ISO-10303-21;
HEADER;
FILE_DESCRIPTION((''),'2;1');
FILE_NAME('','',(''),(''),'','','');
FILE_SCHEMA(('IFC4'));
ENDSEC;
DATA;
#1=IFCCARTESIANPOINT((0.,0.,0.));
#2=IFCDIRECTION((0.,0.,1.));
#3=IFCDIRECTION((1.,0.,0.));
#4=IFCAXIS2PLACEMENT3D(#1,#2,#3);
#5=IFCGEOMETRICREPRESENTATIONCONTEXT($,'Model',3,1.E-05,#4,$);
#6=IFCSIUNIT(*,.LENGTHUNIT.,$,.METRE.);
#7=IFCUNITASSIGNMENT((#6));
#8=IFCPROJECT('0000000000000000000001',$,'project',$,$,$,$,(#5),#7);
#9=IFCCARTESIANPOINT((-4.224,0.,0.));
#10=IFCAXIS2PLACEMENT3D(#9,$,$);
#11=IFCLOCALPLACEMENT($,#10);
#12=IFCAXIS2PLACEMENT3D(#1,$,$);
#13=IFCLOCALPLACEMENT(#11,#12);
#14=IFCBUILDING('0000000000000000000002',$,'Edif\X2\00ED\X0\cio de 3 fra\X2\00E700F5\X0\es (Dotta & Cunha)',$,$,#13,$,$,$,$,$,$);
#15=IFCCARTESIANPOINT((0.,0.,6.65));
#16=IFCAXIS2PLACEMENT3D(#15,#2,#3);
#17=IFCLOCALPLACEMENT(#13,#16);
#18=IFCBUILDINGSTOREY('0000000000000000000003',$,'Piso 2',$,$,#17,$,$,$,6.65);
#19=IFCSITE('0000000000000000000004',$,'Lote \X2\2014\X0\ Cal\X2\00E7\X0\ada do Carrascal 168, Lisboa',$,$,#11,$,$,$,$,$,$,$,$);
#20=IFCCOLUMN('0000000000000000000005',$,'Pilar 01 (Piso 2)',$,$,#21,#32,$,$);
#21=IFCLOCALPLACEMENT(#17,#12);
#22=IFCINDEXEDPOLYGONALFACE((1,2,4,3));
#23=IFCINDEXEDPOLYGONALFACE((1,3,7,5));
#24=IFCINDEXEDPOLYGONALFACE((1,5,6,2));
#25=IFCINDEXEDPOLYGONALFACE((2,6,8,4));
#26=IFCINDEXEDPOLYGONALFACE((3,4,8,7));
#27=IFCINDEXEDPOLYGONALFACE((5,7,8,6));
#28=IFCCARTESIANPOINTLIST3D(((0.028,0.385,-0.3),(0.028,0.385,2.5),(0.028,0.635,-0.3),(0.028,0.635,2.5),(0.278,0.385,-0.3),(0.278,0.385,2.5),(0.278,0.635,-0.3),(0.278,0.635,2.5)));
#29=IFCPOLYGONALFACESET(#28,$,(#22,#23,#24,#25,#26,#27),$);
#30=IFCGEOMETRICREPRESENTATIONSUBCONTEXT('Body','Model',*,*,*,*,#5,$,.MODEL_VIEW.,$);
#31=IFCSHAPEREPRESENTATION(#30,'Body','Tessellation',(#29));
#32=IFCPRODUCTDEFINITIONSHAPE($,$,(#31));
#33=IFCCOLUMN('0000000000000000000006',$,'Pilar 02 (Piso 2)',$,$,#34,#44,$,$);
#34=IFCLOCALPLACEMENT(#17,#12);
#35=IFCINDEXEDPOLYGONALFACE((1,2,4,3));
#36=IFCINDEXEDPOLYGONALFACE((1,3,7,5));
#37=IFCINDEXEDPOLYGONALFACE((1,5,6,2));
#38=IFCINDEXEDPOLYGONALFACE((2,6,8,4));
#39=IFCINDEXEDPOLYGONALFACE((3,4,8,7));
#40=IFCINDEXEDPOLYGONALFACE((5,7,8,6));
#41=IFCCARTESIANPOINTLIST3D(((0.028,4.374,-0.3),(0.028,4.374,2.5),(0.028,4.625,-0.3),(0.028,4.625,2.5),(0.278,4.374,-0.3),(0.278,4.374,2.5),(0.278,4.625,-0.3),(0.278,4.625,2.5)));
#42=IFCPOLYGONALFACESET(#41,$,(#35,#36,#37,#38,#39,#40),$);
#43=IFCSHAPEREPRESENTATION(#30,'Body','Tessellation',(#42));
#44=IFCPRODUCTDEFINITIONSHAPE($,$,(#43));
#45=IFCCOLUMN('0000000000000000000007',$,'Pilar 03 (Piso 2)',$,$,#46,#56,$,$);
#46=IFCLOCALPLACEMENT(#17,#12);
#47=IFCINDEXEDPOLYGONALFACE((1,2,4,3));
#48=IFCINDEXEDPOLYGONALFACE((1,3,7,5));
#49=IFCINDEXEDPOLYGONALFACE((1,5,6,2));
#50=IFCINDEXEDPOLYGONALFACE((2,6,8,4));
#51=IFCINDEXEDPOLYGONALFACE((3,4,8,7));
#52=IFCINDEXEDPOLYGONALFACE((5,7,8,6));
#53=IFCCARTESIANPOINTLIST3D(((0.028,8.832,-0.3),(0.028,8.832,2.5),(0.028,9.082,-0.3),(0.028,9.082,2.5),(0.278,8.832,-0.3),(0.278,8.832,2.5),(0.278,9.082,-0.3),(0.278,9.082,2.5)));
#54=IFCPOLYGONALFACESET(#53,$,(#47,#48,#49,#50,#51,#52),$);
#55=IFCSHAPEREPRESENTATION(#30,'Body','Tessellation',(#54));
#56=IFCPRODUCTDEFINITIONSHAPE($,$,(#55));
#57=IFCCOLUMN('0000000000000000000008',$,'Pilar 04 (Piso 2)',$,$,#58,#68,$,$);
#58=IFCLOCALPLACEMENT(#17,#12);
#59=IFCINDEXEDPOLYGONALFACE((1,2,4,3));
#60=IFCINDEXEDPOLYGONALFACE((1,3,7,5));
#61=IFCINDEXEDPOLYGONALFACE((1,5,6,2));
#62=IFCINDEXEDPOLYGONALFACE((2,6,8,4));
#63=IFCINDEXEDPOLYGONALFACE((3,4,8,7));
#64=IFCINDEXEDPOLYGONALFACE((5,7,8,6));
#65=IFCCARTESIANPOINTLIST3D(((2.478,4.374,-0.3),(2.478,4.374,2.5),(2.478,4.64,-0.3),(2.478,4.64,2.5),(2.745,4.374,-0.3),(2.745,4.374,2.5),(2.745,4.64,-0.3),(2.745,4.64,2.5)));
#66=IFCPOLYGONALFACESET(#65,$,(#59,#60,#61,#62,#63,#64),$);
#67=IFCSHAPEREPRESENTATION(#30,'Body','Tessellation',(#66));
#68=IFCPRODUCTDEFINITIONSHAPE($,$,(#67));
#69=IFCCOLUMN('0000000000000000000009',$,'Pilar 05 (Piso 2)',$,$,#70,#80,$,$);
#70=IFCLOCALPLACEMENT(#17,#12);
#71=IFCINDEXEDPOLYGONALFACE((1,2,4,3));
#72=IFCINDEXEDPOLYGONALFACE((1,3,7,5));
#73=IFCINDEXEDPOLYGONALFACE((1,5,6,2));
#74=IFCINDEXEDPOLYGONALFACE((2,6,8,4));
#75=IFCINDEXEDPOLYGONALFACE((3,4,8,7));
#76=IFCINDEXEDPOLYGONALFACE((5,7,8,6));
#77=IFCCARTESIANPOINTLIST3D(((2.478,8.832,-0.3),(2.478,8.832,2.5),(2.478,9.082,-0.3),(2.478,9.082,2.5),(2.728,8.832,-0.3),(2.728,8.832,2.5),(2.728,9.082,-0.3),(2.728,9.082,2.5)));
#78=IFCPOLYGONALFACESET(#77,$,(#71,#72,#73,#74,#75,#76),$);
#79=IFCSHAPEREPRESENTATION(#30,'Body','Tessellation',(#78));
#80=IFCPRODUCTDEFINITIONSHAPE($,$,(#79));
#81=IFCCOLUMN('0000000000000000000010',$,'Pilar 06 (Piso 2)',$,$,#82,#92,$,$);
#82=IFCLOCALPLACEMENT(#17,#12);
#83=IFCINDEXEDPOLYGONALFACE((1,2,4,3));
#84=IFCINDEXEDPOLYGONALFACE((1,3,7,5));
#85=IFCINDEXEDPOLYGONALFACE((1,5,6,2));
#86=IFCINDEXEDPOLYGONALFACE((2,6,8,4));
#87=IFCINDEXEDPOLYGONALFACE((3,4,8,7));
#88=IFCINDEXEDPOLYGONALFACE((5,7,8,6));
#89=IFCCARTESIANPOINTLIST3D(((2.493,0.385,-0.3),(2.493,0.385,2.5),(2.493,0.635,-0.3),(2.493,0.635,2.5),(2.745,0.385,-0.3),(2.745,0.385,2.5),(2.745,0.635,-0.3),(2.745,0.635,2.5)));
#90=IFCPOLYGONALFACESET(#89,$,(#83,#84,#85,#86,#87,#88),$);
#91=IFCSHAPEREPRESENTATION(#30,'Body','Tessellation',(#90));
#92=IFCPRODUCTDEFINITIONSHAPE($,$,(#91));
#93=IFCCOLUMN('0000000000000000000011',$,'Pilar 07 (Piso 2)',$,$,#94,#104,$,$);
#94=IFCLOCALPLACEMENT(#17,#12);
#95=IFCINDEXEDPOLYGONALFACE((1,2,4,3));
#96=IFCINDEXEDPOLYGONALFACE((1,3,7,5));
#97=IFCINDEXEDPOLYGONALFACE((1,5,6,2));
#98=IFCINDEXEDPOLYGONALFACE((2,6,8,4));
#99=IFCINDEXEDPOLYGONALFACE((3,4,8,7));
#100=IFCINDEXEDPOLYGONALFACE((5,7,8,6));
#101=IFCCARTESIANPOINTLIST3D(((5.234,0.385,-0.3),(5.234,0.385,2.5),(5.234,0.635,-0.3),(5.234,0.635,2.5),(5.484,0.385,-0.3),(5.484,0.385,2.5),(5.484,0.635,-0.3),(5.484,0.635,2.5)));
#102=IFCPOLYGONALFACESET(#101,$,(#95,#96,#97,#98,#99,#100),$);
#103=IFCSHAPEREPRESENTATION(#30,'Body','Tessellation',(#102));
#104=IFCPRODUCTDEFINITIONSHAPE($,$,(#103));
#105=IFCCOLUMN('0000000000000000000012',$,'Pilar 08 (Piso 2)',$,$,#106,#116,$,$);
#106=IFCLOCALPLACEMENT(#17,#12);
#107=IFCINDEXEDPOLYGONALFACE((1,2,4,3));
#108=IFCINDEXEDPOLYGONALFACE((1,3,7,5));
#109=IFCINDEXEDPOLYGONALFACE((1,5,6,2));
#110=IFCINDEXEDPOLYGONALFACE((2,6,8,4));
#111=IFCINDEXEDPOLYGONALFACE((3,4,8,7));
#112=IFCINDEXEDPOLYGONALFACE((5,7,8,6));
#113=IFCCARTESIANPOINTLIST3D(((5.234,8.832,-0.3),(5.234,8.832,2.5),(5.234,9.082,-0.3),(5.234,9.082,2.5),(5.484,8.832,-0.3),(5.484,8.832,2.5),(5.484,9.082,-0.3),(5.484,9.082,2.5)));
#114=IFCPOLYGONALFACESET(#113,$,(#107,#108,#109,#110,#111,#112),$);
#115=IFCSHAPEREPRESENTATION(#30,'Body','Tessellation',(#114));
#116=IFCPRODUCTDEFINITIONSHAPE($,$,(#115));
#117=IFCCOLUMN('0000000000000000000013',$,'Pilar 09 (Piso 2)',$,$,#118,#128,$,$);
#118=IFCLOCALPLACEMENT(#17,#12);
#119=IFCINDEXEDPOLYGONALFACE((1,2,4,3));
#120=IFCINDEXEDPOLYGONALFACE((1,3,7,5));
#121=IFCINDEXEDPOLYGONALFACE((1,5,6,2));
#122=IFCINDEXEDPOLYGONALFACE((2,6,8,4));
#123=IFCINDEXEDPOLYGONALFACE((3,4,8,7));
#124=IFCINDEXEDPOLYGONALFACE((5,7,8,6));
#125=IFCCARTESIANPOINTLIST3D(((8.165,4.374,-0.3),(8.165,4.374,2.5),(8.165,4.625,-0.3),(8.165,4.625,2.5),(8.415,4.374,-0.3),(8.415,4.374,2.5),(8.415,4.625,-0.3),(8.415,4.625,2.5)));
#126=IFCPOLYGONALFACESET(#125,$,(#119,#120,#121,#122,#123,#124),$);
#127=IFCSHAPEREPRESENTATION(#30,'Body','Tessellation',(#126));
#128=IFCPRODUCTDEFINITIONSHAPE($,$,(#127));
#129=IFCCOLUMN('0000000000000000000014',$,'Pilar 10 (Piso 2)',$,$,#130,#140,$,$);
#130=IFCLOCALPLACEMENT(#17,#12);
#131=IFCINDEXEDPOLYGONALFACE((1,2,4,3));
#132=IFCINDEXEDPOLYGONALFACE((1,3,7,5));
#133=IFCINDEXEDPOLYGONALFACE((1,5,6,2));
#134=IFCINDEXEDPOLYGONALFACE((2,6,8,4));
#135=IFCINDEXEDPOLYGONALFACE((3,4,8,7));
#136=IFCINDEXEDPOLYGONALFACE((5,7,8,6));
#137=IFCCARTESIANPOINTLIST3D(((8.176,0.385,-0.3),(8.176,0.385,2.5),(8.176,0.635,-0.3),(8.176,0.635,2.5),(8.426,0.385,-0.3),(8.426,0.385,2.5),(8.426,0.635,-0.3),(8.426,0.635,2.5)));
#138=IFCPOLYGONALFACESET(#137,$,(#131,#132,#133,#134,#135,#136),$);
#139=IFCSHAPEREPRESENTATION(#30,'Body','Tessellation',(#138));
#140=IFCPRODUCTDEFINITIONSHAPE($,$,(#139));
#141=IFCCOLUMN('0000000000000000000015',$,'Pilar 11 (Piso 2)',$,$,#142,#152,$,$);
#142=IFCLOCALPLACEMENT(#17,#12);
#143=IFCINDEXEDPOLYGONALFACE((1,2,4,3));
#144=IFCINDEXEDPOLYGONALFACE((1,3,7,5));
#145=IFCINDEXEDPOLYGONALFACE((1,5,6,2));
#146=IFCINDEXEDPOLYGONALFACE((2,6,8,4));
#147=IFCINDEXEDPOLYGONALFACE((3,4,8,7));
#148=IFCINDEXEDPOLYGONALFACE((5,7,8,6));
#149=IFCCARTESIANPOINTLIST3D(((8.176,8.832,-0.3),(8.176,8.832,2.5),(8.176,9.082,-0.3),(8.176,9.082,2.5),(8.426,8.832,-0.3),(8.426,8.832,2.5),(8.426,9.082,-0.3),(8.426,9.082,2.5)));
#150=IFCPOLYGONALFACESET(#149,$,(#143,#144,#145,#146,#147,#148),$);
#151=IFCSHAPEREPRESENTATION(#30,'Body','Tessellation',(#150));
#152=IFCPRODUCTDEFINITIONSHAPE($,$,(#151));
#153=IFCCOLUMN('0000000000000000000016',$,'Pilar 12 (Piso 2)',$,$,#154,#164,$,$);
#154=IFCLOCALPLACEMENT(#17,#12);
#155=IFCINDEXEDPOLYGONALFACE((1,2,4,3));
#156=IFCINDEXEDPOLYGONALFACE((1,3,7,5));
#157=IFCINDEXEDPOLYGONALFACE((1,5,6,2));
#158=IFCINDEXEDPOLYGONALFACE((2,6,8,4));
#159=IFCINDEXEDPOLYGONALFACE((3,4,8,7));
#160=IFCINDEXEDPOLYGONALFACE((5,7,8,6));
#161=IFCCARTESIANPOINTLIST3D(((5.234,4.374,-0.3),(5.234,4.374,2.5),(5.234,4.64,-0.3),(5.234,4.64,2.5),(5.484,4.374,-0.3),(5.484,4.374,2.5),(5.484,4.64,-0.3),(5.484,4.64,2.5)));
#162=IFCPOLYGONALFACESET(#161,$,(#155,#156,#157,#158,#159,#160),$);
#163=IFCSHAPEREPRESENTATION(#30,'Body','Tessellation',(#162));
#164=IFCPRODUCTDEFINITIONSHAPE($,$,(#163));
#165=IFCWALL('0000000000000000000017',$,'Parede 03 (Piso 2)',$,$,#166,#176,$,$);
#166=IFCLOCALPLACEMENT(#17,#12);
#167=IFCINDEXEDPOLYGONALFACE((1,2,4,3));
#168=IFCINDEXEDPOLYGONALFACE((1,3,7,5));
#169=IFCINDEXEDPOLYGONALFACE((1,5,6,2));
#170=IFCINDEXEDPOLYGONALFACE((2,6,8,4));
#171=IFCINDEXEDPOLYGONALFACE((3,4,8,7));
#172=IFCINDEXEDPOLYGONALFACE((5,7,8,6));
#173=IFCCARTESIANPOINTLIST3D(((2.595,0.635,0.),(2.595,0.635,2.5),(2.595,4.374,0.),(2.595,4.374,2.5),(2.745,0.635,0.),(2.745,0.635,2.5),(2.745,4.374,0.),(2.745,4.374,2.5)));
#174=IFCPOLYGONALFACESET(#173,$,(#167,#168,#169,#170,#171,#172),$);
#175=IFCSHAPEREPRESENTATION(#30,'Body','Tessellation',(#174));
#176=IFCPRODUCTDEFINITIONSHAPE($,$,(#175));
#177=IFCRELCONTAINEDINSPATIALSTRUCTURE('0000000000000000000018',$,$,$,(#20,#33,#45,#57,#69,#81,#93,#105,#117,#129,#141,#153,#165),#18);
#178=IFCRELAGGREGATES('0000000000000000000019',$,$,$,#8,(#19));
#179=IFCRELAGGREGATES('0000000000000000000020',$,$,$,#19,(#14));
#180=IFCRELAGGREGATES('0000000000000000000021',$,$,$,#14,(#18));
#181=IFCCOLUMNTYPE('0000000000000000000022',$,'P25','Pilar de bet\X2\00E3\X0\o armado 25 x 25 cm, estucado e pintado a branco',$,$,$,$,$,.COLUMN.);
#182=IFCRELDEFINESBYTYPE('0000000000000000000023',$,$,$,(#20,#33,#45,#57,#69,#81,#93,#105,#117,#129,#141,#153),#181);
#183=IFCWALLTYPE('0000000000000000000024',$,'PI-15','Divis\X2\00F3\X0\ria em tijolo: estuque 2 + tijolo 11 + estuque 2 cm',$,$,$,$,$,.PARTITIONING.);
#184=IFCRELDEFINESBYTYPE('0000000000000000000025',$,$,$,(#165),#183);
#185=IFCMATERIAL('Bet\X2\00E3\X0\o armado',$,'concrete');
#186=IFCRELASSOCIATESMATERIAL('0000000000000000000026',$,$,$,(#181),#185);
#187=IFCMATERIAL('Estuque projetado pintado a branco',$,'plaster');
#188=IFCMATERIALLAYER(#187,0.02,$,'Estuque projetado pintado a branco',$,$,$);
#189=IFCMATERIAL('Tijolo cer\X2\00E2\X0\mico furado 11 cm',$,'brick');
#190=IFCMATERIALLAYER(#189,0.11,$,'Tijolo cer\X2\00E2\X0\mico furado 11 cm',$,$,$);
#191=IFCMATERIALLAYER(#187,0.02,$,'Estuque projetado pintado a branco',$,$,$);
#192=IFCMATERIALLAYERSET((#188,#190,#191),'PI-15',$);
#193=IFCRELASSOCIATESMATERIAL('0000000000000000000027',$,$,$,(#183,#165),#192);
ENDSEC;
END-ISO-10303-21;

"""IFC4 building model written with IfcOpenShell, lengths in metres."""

from ifc_helpers import new_model, si_unit, frame, origin, origin_with_axes, place, context, subcontext, project, spatial, line, indexed_curve, outline, extrude, material, layer, layer_set, layer_usage, type_object, element, save


model = new_model("IFC4")

# Units and contexts
model_context = context("Model", 3, precision=1e-05, world=origin_with_axes())
body_context = subcontext(model_context, "Body", "Model", "MODEL_VIEW")
ifc_project = project(units=[si_unit("LENGTHUNIT", "METRE")], contexts=[model_context])

# Site, building, storey
site_placement = place(None, frame((-4.224, 0.0, 0.0)))
site = spatial("IfcSite", under=ifc_project, at=site_placement, Name="Lote — Calçada do Carrascal 168, Lisboa")
building_placement = place(site_placement, origin())
building = spatial("IfcBuilding", under=site, at=building_placement, Name="Edifício de 3 frações (Dotta & Cunha)")
storey_placement = place(building_placement, frame((0.0, 0.0, 6.65), z_axis=(0.0, 0.0, 1.0), x_axis=(1.0, 0.0, 0.0)))
storey = spatial("IfcBuildingStorey", under=building, at=storey_placement, Name="Piso 2", Elevation=6.65)

# Columns
ifc_material_1 = material(Name="Betão armado", Category="concrete")
column_type = type_object("IfcColumnType", Name="P25", Description="Pilar de betão armado 25 x 25 cm, estucado e pintado a branco", PredefinedType="COLUMN", material=ifc_material_1)
column_1_placement = place(storey_placement, frame((0.0, 0.0, -0.3), z_axis=(0.0, 0.0, 1.0), x_axis=(1.0, 0.0, 0.0)))
element("IfcColumn", 1, at=column_1_placement, inside=storey, type_object=column_type, Name="Pilar 01 (Piso 2)", context=body_context, shape_type="SweptSolid", body=[
    extrude(outline(indexed_curve([(0.278, 0.385), (0.028, 0.385), (0.028, 0.635), (0.278, 0.635)], segments=[line(1, 2, 3, 4, 1)])), origin_with_axes(), (0.0, 0.0, 1.0), 2.8),
])
column_2_placement = place(storey_placement, frame((0.0, 0.0, -0.3), z_axis=(0.0, 0.0, 1.0), x_axis=(1.0, 0.0, 0.0)))
element("IfcColumn", 2, at=column_2_placement, inside=storey, type_object=column_type, Name="Pilar 02 (Piso 2)", context=body_context, shape_type="SweptSolid", body=[
    extrude(outline(indexed_curve([(0.278, 4.374), (0.028, 4.374), (0.028, 4.625), (0.278, 4.625)], segments=[line(1, 2, 3, 4, 1)])), origin_with_axes(), (0.0, 0.0, 1.0), 2.8),
])
column_3_placement = place(storey_placement, frame((0.0, 0.0, -0.3), z_axis=(0.0, 0.0, 1.0), x_axis=(1.0, 0.0, 0.0)))
element("IfcColumn", 3, at=column_3_placement, inside=storey, type_object=column_type, Name="Pilar 03 (Piso 2)", context=body_context, shape_type="SweptSolid", body=[
    extrude(outline(indexed_curve([(0.028, 9.082), (0.278, 9.082), (0.278, 8.832), (0.028, 8.832)], segments=[line(1, 2, 3, 4, 1)])), origin_with_axes(), (0.0, 0.0, 1.0), 2.8),
])
column_4_placement = place(storey_placement, frame((0.0, 0.0, -0.3), z_axis=(0.0, 0.0, 1.0), x_axis=(1.0, 0.0, 0.0)))
element("IfcColumn", 4, at=column_4_placement, inside=storey, type_object=column_type, Name="Pilar 04 (Piso 2)", context=body_context, shape_type="SweptSolid", body=[
    extrude(outline(indexed_curve([(2.478, 4.64), (2.745, 4.64), (2.745, 4.374), (2.478, 4.374)], segments=[line(1, 2, 3, 4, 1)])), origin_with_axes(), (0.0, 0.0, 1.0), 2.8),
])
column_5_placement = place(storey_placement, frame((0.0, 0.0, -0.3), z_axis=(0.0, 0.0, 1.0), x_axis=(1.0, 0.0, 0.0)))
element("IfcColumn", 5, at=column_5_placement, inside=storey, type_object=column_type, Name="Pilar 05 (Piso 2)", context=body_context, shape_type="SweptSolid", body=[
    extrude(outline(indexed_curve([(2.478, 9.082), (2.728, 9.082), (2.728, 8.832), (2.478, 8.832)], segments=[line(1, 2, 3, 4, 1)])), origin_with_axes(), (0.0, 0.0, 1.0), 2.8),
])
column_6_placement = place(storey_placement, frame((0.0, 0.0, -0.3), z_axis=(0.0, 0.0, 1.0), x_axis=(1.0, 0.0, 0.0)))
element("IfcColumn", 6, at=column_6_placement, inside=storey, type_object=column_type, Name="Pilar 06 (Piso 2)", context=body_context, shape_type="SweptSolid", body=[
    extrude(outline(indexed_curve([(2.493, 0.385), (2.493, 0.635), (2.745, 0.635), (2.745, 0.385)], segments=[line(1, 2, 3, 4, 1)])), origin_with_axes(), (0.0, 0.0, 1.0), 2.8),
])
column_7_placement = place(storey_placement, frame((0.0, 0.0, -0.3), z_axis=(0.0, 0.0, 1.0), x_axis=(1.0, 0.0, 0.0)))
element("IfcColumn", 7, at=column_7_placement, inside=storey, type_object=column_type, Name="Pilar 07 (Piso 2)", context=body_context, shape_type="SweptSolid", body=[
    extrude(outline(indexed_curve([(5.234, 0.385), (5.234, 0.635), (5.484, 0.635), (5.484, 0.385)], segments=[line(1, 2, 3, 4, 1)])), origin_with_axes(), (0.0, 0.0, 1.0), 2.8),
])
column_8_placement = place(storey_placement, frame((0.0, 0.0, -0.3), z_axis=(0.0, 0.0, 1.0), x_axis=(1.0, 0.0, 0.0)))
element("IfcColumn", 8, at=column_8_placement, inside=storey, type_object=column_type, Name="Pilar 08 (Piso 2)", context=body_context, shape_type="SweptSolid", body=[
    extrude(outline(indexed_curve([(5.234, 9.082), (5.484, 9.082), (5.484, 8.832), (5.234, 8.832)], segments=[line(1, 2, 3, 4, 1)])), origin_with_axes(), (0.0, 0.0, 1.0), 2.8),
])
column_9_placement = place(storey_placement, frame((0.0, 0.0, -0.3), z_axis=(0.0, 0.0, 1.0), x_axis=(1.0, 0.0, 0.0)))
element("IfcColumn", 9, at=column_9_placement, inside=storey, type_object=column_type, Name="Pilar 09 (Piso 2)", context=body_context, shape_type="SweptSolid", body=[
    extrude(outline(indexed_curve([(8.165, 4.625), (8.415, 4.625), (8.415, 4.374), (8.165, 4.374)], segments=[line(1, 2, 3, 4, 1)])), origin_with_axes(), (0.0, 0.0, 1.0), 2.8),
])
column_10_placement = place(storey_placement, frame((0.0, 0.0, -0.3), z_axis=(0.0, 0.0, 1.0), x_axis=(1.0, 0.0, 0.0)))
element("IfcColumn", 10, at=column_10_placement, inside=storey, type_object=column_type, Name="Pilar 10 (Piso 2)", context=body_context, shape_type="SweptSolid", body=[
    extrude(outline(indexed_curve([(8.176, 0.635), (8.426, 0.635), (8.426, 0.385), (8.176, 0.385)], segments=[line(1, 2, 3, 4, 1)])), origin_with_axes(), (0.0, 0.0, 1.0), 2.8),
])
column_11_placement = place(storey_placement, frame((0.0, 0.0, -0.3), z_axis=(0.0, 0.0, 1.0), x_axis=(1.0, 0.0, 0.0)))
element("IfcColumn", 11, at=column_11_placement, inside=storey, type_object=column_type, Name="Pilar 11 (Piso 2)", context=body_context, shape_type="SweptSolid", body=[
    extrude(outline(indexed_curve([(8.176, 9.082), (8.426, 9.082), (8.426, 8.832), (8.176, 8.832)], segments=[line(1, 2, 3, 4, 1)])), origin_with_axes(), (0.0, 0.0, 1.0), 2.8),
])
column_12_placement = place(storey_placement, frame((0.0, 0.0, -0.3), z_axis=(0.0, 0.0, 1.0), x_axis=(1.0, 0.0, 0.0)))
element("IfcColumn", 12, at=column_12_placement, inside=storey, type_object=column_type, Name="Pilar 12 (Piso 2)", context=body_context, shape_type="SweptSolid", body=[
    extrude(outline(indexed_curve([(5.234, 4.374), (5.234, 4.64), (5.484, 4.64), (5.484, 4.374)], segments=[line(1, 2, 3, 4, 1)])), origin_with_axes(), (0.0, 0.0, 1.0), 2.8),
])

# Wall
ifc_material_2 = material(Name="Estuque projetado pintado a branco", Category="plaster")
ifc_layer_1 = layer(ifc_material_2, 0.02, Name="Estuque projetado pintado a branco")
ifc_material_3 = material(Name="Tijolo cerâmico furado 11 cm", Category="brick")
ifc_layer_2 = layer(ifc_material_3, 0.11, Name="Tijolo cerâmico furado 11 cm")
ifc_layer_3 = layer(ifc_material_2, 0.02, Name="Estuque projetado pintado a branco")
ifc_layer_set_1 = layer_set([ifc_layer_1, ifc_layer_2, ifc_layer_3], Name="PI-15")
ifc_layer_usage_1 = layer_usage(ifc_layer_set_1, "AXIS2", "POSITIVE", 0.0)
wall_type_1 = type_object("IfcWallType", Name="PI-15", Description="Divisória em tijolo: estuque 2 + tijolo 11 + estuque 2 cm", PredefinedType="PARTITIONING", material=ifc_layer_set_1)
wall_1_placement = place(storey_placement, origin_with_axes())
element("IfcWall", 13, at=wall_1_placement, inside=storey, type_object=wall_type_1, material=ifc_layer_usage_1, Name="Parede 03 (Piso 2)", context=body_context, shape_type="SweptSolid", body=[
    extrude(outline(indexed_curve([(2.745, 0.635), (2.745, 4.374), (2.595, 4.374), (2.595, 0.635)], segments=[line(1, 2, 3, 4, 1)])), origin_with_axes(), (0.0, 0.0, 1.0), 2.5),
])

save(model, "model.ifc")
